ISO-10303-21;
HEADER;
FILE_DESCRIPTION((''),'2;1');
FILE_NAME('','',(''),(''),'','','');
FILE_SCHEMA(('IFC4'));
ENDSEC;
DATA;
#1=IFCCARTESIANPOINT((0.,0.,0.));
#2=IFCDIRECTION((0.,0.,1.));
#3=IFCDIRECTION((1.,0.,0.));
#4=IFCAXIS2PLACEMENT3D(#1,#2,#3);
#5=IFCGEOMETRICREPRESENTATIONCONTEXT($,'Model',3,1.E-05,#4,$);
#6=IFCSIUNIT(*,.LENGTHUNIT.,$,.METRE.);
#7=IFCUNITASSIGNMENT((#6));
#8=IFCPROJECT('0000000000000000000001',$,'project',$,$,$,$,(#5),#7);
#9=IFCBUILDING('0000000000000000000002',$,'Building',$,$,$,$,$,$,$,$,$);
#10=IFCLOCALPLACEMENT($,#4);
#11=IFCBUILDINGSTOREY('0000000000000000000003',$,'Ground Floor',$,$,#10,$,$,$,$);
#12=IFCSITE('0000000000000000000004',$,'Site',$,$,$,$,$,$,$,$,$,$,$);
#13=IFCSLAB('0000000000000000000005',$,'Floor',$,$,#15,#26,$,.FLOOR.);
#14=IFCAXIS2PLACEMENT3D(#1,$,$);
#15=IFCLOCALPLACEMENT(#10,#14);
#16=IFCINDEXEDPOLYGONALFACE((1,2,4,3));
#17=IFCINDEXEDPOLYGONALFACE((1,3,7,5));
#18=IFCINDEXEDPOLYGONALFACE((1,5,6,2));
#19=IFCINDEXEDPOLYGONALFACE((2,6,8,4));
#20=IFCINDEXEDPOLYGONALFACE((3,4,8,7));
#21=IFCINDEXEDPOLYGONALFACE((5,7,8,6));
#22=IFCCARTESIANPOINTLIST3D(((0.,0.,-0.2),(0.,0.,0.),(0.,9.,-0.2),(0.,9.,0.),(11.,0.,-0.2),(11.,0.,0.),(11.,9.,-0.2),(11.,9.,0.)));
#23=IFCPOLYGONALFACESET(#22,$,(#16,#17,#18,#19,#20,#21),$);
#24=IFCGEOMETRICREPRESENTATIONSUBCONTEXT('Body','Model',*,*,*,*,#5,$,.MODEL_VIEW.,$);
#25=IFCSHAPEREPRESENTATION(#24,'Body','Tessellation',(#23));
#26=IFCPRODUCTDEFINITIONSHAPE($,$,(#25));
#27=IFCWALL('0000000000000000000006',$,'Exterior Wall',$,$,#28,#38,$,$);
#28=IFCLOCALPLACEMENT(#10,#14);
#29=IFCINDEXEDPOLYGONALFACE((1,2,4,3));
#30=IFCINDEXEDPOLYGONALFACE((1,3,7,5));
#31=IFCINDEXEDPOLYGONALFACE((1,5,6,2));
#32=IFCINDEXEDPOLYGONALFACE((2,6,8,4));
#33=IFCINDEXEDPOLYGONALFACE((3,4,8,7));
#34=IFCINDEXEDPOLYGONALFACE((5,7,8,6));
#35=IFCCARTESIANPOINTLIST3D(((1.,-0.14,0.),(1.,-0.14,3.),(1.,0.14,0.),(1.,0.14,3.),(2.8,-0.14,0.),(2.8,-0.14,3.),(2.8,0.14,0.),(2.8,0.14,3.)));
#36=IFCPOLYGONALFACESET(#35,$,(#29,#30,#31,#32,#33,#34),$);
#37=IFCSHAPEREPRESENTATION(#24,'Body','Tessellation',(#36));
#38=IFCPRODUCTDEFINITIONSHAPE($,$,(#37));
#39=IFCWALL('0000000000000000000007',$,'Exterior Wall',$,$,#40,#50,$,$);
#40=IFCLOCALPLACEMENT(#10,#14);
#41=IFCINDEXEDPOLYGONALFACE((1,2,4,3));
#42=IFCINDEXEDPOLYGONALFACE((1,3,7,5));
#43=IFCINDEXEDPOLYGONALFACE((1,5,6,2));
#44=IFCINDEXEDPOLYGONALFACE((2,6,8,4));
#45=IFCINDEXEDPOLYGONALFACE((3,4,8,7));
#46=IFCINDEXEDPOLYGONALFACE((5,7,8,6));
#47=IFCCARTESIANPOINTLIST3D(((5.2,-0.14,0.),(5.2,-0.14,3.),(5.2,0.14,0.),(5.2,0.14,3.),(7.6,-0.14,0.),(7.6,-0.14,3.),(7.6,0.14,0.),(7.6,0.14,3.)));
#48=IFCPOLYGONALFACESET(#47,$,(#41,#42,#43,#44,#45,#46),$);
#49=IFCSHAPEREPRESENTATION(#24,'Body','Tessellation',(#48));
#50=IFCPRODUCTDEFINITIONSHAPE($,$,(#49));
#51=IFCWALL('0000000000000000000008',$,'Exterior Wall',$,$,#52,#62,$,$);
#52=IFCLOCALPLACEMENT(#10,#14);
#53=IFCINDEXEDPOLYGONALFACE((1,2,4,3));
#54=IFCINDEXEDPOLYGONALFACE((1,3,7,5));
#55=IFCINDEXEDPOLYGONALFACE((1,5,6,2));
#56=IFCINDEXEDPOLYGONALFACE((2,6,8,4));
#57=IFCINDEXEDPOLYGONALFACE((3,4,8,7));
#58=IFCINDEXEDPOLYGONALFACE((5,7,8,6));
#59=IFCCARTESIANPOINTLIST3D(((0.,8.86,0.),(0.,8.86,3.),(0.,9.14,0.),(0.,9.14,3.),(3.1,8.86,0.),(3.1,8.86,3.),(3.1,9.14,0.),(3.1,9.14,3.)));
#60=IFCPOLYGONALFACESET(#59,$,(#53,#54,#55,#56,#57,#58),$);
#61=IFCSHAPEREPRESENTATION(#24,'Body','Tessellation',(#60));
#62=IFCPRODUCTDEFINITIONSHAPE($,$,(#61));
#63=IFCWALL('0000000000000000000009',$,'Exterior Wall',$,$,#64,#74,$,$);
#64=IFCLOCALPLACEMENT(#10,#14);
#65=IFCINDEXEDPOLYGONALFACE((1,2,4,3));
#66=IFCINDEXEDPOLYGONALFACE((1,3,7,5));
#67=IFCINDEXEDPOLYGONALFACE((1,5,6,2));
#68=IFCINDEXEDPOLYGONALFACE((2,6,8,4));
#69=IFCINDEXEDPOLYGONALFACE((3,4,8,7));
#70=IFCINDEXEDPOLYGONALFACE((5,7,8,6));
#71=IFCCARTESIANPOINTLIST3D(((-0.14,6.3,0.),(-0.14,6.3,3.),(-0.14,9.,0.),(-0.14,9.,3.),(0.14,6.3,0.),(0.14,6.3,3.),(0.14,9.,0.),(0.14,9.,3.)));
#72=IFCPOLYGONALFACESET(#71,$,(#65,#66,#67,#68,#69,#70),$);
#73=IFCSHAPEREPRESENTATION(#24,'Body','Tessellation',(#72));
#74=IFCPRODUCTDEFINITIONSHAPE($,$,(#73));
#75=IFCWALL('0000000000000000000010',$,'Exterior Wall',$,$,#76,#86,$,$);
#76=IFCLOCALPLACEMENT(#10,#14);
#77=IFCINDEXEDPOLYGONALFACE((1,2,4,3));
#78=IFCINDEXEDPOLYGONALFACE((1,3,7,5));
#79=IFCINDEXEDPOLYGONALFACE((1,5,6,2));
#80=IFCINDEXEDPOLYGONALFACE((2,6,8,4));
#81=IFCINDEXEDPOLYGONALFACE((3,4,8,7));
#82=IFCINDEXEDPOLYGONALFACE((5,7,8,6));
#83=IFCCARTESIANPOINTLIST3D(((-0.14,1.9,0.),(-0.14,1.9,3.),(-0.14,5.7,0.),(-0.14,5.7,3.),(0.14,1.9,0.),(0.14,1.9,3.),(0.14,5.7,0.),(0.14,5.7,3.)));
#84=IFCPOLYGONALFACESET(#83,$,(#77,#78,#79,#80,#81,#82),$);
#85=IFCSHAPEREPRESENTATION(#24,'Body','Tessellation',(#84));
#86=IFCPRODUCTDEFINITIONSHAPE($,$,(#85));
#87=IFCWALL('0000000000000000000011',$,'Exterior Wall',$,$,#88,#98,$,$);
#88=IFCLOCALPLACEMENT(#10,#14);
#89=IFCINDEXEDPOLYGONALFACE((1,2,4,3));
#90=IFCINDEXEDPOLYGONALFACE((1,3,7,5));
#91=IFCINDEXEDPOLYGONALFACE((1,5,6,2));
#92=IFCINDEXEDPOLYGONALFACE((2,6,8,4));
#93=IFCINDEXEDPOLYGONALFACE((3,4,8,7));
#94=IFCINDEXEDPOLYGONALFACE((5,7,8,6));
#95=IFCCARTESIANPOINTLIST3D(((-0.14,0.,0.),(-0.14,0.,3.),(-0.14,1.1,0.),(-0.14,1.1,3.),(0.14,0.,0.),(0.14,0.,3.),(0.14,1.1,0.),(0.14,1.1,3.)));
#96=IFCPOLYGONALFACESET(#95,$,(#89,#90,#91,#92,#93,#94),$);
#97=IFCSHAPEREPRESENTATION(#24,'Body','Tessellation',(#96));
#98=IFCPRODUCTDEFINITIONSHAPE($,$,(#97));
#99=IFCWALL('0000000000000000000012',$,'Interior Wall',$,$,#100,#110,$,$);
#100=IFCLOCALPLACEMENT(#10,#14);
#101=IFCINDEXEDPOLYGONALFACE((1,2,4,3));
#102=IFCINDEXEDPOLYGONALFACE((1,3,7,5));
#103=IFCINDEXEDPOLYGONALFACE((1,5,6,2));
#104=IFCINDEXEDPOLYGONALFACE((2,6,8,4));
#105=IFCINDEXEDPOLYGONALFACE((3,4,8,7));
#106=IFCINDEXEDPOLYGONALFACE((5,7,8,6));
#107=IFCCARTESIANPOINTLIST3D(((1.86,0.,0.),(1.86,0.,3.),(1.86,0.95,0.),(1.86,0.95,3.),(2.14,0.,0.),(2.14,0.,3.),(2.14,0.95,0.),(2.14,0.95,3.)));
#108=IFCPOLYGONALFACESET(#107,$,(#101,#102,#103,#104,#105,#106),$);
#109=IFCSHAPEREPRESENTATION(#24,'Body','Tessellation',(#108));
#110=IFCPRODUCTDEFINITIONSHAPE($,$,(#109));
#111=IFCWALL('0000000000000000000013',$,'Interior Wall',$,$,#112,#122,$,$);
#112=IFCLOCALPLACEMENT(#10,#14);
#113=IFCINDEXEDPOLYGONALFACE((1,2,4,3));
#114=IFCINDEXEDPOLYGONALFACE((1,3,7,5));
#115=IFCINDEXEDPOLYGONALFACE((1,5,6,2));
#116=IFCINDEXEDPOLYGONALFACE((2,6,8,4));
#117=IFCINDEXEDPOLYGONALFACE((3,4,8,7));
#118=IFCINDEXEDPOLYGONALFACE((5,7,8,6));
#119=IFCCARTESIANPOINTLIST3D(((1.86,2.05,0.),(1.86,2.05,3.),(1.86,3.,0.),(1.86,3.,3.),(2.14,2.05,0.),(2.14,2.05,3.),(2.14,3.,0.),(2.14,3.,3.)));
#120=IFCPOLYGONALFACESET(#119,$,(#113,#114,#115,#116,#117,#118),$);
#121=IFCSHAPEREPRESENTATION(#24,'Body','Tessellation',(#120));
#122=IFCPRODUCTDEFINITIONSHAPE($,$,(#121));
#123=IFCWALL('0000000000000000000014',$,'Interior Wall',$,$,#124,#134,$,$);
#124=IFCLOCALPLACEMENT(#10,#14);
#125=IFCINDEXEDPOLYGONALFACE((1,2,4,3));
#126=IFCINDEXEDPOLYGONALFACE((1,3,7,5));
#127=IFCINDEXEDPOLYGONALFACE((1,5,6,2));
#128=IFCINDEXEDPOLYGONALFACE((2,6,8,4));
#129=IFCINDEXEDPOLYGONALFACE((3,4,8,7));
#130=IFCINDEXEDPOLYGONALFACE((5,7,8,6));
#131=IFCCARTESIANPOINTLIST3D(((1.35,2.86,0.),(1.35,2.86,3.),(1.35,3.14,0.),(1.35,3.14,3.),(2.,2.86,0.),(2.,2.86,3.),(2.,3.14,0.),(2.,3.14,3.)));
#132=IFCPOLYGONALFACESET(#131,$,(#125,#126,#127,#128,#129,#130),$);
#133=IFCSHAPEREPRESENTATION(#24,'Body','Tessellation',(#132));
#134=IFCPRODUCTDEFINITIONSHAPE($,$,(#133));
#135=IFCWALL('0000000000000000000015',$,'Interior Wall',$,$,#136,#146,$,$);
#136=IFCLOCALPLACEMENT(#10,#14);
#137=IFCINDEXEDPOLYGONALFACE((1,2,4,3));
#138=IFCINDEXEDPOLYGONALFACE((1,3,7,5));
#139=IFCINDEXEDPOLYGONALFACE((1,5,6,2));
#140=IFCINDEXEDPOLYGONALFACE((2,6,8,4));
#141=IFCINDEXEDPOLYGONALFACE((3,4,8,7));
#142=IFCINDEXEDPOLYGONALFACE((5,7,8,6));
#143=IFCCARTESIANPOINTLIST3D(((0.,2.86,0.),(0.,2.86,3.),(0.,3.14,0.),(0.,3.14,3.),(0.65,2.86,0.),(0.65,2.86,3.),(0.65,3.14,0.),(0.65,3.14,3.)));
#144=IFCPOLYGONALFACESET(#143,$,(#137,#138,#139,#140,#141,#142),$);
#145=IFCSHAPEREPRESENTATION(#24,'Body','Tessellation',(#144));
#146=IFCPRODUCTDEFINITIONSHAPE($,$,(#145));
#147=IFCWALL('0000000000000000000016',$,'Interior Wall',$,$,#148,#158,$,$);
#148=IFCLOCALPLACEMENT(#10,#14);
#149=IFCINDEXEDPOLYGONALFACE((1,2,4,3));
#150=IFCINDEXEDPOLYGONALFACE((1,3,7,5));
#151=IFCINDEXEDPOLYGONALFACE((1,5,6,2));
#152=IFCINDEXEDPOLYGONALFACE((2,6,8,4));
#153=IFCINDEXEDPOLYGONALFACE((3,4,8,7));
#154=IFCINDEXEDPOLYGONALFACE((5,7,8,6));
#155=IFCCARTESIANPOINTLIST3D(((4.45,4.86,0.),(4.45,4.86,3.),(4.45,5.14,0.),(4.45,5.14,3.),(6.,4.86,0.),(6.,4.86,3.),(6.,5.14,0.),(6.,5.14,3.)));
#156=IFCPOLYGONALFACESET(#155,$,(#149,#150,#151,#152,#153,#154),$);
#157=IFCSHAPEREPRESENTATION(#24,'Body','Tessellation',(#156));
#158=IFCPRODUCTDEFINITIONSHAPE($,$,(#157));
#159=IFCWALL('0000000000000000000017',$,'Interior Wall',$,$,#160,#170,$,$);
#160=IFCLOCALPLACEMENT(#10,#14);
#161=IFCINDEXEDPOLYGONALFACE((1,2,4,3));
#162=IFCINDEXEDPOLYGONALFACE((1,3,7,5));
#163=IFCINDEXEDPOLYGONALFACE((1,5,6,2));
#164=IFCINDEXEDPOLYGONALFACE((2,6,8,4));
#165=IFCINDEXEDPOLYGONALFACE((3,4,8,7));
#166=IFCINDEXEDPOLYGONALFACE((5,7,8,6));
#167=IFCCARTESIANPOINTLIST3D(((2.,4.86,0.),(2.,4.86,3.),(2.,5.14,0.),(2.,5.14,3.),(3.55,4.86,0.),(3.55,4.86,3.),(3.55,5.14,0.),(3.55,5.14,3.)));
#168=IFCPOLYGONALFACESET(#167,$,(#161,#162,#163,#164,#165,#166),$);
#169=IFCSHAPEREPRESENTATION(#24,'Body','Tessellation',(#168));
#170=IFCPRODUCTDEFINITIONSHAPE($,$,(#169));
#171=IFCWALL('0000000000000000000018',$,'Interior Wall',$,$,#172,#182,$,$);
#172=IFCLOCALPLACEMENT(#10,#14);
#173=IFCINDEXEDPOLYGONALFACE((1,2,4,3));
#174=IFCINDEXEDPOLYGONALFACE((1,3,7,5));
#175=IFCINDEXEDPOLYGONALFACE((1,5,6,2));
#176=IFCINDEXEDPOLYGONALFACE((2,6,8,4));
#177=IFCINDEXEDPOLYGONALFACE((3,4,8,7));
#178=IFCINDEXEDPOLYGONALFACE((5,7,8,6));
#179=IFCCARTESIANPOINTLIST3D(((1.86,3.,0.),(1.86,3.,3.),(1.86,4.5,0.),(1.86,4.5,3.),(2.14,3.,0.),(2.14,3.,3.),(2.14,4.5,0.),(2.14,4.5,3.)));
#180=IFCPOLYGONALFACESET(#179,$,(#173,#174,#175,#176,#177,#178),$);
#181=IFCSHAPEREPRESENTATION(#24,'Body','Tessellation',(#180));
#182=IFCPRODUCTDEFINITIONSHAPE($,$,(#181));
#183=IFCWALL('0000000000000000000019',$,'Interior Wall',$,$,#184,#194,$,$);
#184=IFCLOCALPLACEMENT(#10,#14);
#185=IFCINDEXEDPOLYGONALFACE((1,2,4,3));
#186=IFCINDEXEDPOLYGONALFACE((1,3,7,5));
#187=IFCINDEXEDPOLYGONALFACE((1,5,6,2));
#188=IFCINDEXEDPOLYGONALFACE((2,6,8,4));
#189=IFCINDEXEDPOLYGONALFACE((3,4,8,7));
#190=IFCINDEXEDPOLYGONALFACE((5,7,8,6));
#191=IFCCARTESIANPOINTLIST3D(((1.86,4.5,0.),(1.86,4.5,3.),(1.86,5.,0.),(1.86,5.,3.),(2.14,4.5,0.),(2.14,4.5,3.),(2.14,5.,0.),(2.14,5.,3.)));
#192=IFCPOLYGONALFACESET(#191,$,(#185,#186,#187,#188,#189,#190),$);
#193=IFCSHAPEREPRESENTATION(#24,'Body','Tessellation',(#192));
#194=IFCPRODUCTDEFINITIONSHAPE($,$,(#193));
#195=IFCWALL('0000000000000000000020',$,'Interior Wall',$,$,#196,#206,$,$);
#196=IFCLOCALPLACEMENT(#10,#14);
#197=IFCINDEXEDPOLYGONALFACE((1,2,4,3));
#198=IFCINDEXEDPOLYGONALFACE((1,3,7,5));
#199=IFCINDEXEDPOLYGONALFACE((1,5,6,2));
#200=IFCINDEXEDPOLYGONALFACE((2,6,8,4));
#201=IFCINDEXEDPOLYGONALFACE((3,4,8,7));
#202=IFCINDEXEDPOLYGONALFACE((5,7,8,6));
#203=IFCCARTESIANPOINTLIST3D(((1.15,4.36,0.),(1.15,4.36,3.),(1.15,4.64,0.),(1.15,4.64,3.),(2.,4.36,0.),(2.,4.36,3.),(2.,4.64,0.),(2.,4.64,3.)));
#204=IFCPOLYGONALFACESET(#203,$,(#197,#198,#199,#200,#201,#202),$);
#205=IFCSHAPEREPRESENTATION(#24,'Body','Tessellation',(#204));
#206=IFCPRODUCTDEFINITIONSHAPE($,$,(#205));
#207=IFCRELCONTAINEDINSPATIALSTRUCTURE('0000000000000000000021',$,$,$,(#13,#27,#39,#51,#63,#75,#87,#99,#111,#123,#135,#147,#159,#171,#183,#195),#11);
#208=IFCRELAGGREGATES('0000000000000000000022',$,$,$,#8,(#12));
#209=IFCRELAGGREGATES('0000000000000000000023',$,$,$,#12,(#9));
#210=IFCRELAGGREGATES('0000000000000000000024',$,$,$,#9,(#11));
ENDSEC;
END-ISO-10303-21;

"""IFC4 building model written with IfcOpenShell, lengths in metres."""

from ifc_helpers import new_model, si_unit, frame, origin_with_axes, place, context, subcontext, project, spatial, indexed_curve, outline, extrude, element, save


model = new_model("IFC4")

# Units and contexts
model_context = context("Model", 3, precision=1e-05, world=origin_with_axes())
body_context = subcontext(model_context, "Body", "Model", "MODEL_VIEW")
ifc_project = project(units=[si_unit("LENGTHUNIT", "METRE")], contexts=[model_context])

# Site, building, storey
site = spatial("IfcSite", under=ifc_project, Name="Site")
building = spatial("IfcBuilding", under=site, Name="Building")
storey_placement = place(None, origin_with_axes())
storey = spatial("IfcBuildingStorey", under=building, at=storey_placement, Name="Ground Floor")

# Slab
slab_placement = place(storey_placement, frame((0.0, 0.0, -0.2), z_axis=(0.0, 0.0, 1.0), x_axis=(1.0, 0.0, 0.0)))
element("IfcSlab", 1, at=slab_placement, inside=storey, Name="Floor", PredefinedType="FLOOR", context=body_context, shape_type="SweptSolid", body=[
    extrude(outline(indexed_curve([(0.0, 0.0), (11.0, 0.0), (11.0, 9.0), (0.0, 9.0)])), None, (0.0, 0.0, 1.0), 0.2),
])

# Walls
wall_1_placement = place(storey_placement, frame((1.0, 0.0, 0.0), z_axis=(0.0, 0.0, 1.0), x_axis=(1.0, 0.0, 0.0)))
element("IfcWall", 2, at=wall_1_placement, inside=storey, Name="Exterior Wall", context=body_context, shape_type="SweptSolid", body=[
    extrude(outline(indexed_curve([(0.0, 0.0), (0.0, 0.28), (1.8, 0.28), (1.8, 0.0), (0.0, 0.0)], self_intersect=False)), frame((0.0, -0.14, 0.0), z_axis=(0.0, 0.0, 1.0), x_axis=(1.0, 0.0, 0.0)), (0.0, 0.0, 1.0), 3.0),
])
wall_2_placement = place(storey_placement, frame((5.2, 0.0, 0.0), z_axis=(0.0, 0.0, 1.0), x_axis=(1.0, 0.0, 0.0)))
element("IfcWall", 3, at=wall_2_placement, inside=storey, Name="Exterior Wall", context=body_context, shape_type="SweptSolid", body=[
    extrude(outline(indexed_curve([(0.0, 0.0), (0.0, 0.28), (2.4, 0.28), (2.4, 0.0), (0.0, 0.0)], self_intersect=False)), frame((0.0, -0.14, 0.0), z_axis=(0.0, 0.0, 1.0), x_axis=(1.0, 0.0, 0.0)), (0.0, 0.0, 1.0), 3.0),
])
wall_3_placement = place(storey_placement, frame((3.1, 9.0, 0.0), z_axis=(0.0, 0.0, 1.0), x_axis=(-1.0, 0.0, 0.0)))
element("IfcWall", 4, at=wall_3_placement, inside=storey, Name="Exterior Wall", context=body_context, shape_type="SweptSolid", body=[
    extrude(outline(indexed_curve([(0.0, 0.0), (0.0, 0.28), (3.1, 0.28), (3.1, 0.0), (0.0, 0.0)], self_intersect=False)), frame((0.0, -0.14, 0.0), z_axis=(0.0, 0.0, 1.0), x_axis=(1.0, 0.0, 0.0)), (0.0, 0.0, 1.0), 3.0),
])
wall_4_placement = place(storey_placement, frame((0.0, 9.0, 0.0), z_axis=(0.0, 0.0, 1.0), x_axis=(0.0, -1.0, 0.0)))
element("IfcWall", 5, at=wall_4_placement, inside=storey, Name="Exterior Wall", context=body_context, shape_type="SweptSolid", body=[
    extrude(outline(indexed_curve([(0.0, 0.0), (0.0, 0.28), (2.7, 0.28), (2.7, 0.0), (0.0, 0.0)], self_intersect=False)), frame((0.0, -0.14, 0.0), z_axis=(0.0, 0.0, 1.0), x_axis=(1.0, 0.0, 0.0)), (0.0, 0.0, 1.0), 3.0),
])
wall_5_placement = place(storey_placement, frame((0.0, 5.7, 0.0), z_axis=(0.0, 0.0, 1.0), x_axis=(0.0, -1.0, 0.0)))
element("IfcWall", 6, at=wall_5_placement, inside=storey, Name="Exterior Wall", context=body_context, shape_type="SweptSolid", body=[
    extrude(outline(indexed_curve([(0.0, 0.0), (0.0, 0.28), (3.8, 0.28), (3.8, 0.0), (0.0, 0.0)], self_intersect=False)), frame((0.0, -0.14, 0.0), z_axis=(0.0, 0.0, 1.0), x_axis=(1.0, 0.0, 0.0)), (0.0, 0.0, 1.0), 3.0),
])
wall_6_placement = place(storey_placement, frame((0.0, 1.1, 0.0), z_axis=(0.0, 0.0, 1.0), x_axis=(0.0, -1.0, 0.0)))
element("IfcWall", 7, at=wall_6_placement, inside=storey, Name="Exterior Wall", context=body_context, shape_type="SweptSolid", body=[
    extrude(outline(indexed_curve([(0.0, 0.0), (0.0, 0.28), (1.1, 0.28), (1.1, 0.0), (0.0, 0.0)], self_intersect=False)), frame((0.0, -0.14, 0.0), z_axis=(0.0, 0.0, 1.0), x_axis=(1.0, 0.0, 0.0)), (0.0, 0.0, 1.0), 3.0),
])
wall_7_placement = place(storey_placement, frame((2.0, 0.0, 0.0), z_axis=(0.0, 0.0, 1.0), x_axis=(0.0, 1.0, 0.0)))
element("IfcWall", 8, at=wall_7_placement, inside=storey, Name="Interior Wall", context=body_context, shape_type="SweptSolid", body=[
    extrude(outline(indexed_curve([(0.0, 0.0), (0.0, 0.28), (0.95, 0.28), (0.95, 0.0), (0.0, 0.0)], self_intersect=False)), frame((0.0, -0.14, 0.0), z_axis=(0.0, 0.0, 1.0), x_axis=(1.0, 0.0, 0.0)), (0.0, 0.0, 1.0), 3.0),
])
wall_8_placement = place(storey_placement, frame((2.0, 2.05, 0.0), z_axis=(0.0, 0.0, 1.0), x_axis=(0.0, 1.0, 0.0)))
element("IfcWall", 9, at=wall_8_placement, inside=storey, Name="Interior Wall", context=body_context, shape_type="SweptSolid", body=[
    extrude(outline(indexed_curve([(0.0, 0.0), (0.0, 0.28), (0.95, 0.28), (0.95, 0.0), (0.0, 0.0)], self_intersect=False)), frame((0.0, -0.14, 0.0), z_axis=(0.0, 0.0, 1.0), x_axis=(1.0, 0.0, 0.0)), (0.0, 0.0, 1.0), 3.0),
])
for number, where, z_axis, x_axis, name in (
    (10, (2.0, 3.0, 0.0), (0.0, 0.0, 1.0), (-1.0, 0.0, 0.0), "Interior Wall"),
    (11, (0.65, 3.0, 0.0), (0.0, 0.0, 1.0), (-1.0, 0.0, 0.0), "Interior Wall"),
):
    element("IfcWall", number, at=place(storey_placement, frame(where, z_axis=z_axis, x_axis=x_axis)), inside=storey, Name=name, context=body_context, shape_type="SweptSolid", body=[
        extrude(outline(indexed_curve([(0.0, 0.0), (0.0, 0.28), (0.65, 0.28), (0.65, 0.0), (0.0, 0.0)], self_intersect=False)), frame((0.0, -0.14, 0.0), z_axis=(0.0, 0.0, 1.0), x_axis=(1.0, 0.0, 0.0)), (0.0, 0.0, 1.0), 3.0),
    ])
for number, where, z_axis, x_axis, name in (
    (12, (6.0, 5.0, 0.0), (0.0, 0.0, 1.0), (-1.0, 0.0, 0.0), "Interior Wall"),
    (13, (3.55, 5.0, 0.0), (0.0, 0.0, 1.0), (-1.0, 0.0, 0.0), "Interior Wall"),
):
    element("IfcWall", number, at=place(storey_placement, frame(where, z_axis=z_axis, x_axis=x_axis)), inside=storey, Name=name, context=body_context, shape_type="SweptSolid", body=[
        extrude(outline(indexed_curve([(0.0, 0.0), (0.0, 0.28), (1.55, 0.28), (1.55, 0.0), (0.0, 0.0)], self_intersect=False)), frame((0.0, -0.14, 0.0), z_axis=(0.0, 0.0, 1.0), x_axis=(1.0, 0.0, 0.0)), (0.0, 0.0, 1.0), 3.0),
    ])
wall_9_placement = place(storey_placement, frame((2.0, 4.5, 0.0), z_axis=(0.0, 0.0, 1.0), x_axis=(0.0, -1.0, 0.0)))
element("IfcWall", 14, at=wall_9_placement, inside=storey, Name="Interior Wall", context=body_context, shape_type="SweptSolid", body=[
    extrude(outline(indexed_curve([(0.0, 0.0), (0.0, 0.28), (1.5, 0.28), (1.5, 0.0), (0.0, 0.0)], self_intersect=False)), frame((0.0, -0.14, 0.0), z_axis=(0.0, 0.0, 1.0), x_axis=(1.0, 0.0, 0.0)), (0.0, 0.0, 1.0), 3.0),
])
wall_10_placement = place(storey_placement, frame((2.0, 5.0, 0.0), z_axis=(0.0, 0.0, 1.0), x_axis=(0.0, -1.0, 0.0)))
element("IfcWall", 15, at=wall_10_placement, inside=storey, Name="Interior Wall", context=body_context, shape_type="SweptSolid", body=[
    extrude(outline(indexed_curve([(0.0, 0.0), (0.0, 0.28), (0.5, 0.28), (0.5, 0.0), (0.0, 0.0)], self_intersect=False)), frame((0.0, -0.14, 0.0), z_axis=(0.0, 0.0, 1.0), x_axis=(1.0, 0.0, 0.0)), (0.0, 0.0, 1.0), 3.0),
])
wall_11_placement = place(storey_placement, frame((2.0, 4.5, 0.0), z_axis=(0.0, 0.0, 1.0), x_axis=(-1.0, 0.0, 0.0)))
element("IfcWall", 16, at=wall_11_placement, inside=storey, Name="Interior Wall", context=body_context, shape_type="SweptSolid", body=[
    extrude(outline(indexed_curve([(0.0, 0.0), (0.0, 0.28), (0.85, 0.28), (0.85, 0.0), (0.0, 0.0)], self_intersect=False)), frame((0.0, -0.14, 0.0), z_axis=(0.0, 0.0, 1.0), x_axis=(1.0, 0.0, 0.0)), (0.0, 0.0, 1.0), 3.0),
])

save(model, "model.ifc")
